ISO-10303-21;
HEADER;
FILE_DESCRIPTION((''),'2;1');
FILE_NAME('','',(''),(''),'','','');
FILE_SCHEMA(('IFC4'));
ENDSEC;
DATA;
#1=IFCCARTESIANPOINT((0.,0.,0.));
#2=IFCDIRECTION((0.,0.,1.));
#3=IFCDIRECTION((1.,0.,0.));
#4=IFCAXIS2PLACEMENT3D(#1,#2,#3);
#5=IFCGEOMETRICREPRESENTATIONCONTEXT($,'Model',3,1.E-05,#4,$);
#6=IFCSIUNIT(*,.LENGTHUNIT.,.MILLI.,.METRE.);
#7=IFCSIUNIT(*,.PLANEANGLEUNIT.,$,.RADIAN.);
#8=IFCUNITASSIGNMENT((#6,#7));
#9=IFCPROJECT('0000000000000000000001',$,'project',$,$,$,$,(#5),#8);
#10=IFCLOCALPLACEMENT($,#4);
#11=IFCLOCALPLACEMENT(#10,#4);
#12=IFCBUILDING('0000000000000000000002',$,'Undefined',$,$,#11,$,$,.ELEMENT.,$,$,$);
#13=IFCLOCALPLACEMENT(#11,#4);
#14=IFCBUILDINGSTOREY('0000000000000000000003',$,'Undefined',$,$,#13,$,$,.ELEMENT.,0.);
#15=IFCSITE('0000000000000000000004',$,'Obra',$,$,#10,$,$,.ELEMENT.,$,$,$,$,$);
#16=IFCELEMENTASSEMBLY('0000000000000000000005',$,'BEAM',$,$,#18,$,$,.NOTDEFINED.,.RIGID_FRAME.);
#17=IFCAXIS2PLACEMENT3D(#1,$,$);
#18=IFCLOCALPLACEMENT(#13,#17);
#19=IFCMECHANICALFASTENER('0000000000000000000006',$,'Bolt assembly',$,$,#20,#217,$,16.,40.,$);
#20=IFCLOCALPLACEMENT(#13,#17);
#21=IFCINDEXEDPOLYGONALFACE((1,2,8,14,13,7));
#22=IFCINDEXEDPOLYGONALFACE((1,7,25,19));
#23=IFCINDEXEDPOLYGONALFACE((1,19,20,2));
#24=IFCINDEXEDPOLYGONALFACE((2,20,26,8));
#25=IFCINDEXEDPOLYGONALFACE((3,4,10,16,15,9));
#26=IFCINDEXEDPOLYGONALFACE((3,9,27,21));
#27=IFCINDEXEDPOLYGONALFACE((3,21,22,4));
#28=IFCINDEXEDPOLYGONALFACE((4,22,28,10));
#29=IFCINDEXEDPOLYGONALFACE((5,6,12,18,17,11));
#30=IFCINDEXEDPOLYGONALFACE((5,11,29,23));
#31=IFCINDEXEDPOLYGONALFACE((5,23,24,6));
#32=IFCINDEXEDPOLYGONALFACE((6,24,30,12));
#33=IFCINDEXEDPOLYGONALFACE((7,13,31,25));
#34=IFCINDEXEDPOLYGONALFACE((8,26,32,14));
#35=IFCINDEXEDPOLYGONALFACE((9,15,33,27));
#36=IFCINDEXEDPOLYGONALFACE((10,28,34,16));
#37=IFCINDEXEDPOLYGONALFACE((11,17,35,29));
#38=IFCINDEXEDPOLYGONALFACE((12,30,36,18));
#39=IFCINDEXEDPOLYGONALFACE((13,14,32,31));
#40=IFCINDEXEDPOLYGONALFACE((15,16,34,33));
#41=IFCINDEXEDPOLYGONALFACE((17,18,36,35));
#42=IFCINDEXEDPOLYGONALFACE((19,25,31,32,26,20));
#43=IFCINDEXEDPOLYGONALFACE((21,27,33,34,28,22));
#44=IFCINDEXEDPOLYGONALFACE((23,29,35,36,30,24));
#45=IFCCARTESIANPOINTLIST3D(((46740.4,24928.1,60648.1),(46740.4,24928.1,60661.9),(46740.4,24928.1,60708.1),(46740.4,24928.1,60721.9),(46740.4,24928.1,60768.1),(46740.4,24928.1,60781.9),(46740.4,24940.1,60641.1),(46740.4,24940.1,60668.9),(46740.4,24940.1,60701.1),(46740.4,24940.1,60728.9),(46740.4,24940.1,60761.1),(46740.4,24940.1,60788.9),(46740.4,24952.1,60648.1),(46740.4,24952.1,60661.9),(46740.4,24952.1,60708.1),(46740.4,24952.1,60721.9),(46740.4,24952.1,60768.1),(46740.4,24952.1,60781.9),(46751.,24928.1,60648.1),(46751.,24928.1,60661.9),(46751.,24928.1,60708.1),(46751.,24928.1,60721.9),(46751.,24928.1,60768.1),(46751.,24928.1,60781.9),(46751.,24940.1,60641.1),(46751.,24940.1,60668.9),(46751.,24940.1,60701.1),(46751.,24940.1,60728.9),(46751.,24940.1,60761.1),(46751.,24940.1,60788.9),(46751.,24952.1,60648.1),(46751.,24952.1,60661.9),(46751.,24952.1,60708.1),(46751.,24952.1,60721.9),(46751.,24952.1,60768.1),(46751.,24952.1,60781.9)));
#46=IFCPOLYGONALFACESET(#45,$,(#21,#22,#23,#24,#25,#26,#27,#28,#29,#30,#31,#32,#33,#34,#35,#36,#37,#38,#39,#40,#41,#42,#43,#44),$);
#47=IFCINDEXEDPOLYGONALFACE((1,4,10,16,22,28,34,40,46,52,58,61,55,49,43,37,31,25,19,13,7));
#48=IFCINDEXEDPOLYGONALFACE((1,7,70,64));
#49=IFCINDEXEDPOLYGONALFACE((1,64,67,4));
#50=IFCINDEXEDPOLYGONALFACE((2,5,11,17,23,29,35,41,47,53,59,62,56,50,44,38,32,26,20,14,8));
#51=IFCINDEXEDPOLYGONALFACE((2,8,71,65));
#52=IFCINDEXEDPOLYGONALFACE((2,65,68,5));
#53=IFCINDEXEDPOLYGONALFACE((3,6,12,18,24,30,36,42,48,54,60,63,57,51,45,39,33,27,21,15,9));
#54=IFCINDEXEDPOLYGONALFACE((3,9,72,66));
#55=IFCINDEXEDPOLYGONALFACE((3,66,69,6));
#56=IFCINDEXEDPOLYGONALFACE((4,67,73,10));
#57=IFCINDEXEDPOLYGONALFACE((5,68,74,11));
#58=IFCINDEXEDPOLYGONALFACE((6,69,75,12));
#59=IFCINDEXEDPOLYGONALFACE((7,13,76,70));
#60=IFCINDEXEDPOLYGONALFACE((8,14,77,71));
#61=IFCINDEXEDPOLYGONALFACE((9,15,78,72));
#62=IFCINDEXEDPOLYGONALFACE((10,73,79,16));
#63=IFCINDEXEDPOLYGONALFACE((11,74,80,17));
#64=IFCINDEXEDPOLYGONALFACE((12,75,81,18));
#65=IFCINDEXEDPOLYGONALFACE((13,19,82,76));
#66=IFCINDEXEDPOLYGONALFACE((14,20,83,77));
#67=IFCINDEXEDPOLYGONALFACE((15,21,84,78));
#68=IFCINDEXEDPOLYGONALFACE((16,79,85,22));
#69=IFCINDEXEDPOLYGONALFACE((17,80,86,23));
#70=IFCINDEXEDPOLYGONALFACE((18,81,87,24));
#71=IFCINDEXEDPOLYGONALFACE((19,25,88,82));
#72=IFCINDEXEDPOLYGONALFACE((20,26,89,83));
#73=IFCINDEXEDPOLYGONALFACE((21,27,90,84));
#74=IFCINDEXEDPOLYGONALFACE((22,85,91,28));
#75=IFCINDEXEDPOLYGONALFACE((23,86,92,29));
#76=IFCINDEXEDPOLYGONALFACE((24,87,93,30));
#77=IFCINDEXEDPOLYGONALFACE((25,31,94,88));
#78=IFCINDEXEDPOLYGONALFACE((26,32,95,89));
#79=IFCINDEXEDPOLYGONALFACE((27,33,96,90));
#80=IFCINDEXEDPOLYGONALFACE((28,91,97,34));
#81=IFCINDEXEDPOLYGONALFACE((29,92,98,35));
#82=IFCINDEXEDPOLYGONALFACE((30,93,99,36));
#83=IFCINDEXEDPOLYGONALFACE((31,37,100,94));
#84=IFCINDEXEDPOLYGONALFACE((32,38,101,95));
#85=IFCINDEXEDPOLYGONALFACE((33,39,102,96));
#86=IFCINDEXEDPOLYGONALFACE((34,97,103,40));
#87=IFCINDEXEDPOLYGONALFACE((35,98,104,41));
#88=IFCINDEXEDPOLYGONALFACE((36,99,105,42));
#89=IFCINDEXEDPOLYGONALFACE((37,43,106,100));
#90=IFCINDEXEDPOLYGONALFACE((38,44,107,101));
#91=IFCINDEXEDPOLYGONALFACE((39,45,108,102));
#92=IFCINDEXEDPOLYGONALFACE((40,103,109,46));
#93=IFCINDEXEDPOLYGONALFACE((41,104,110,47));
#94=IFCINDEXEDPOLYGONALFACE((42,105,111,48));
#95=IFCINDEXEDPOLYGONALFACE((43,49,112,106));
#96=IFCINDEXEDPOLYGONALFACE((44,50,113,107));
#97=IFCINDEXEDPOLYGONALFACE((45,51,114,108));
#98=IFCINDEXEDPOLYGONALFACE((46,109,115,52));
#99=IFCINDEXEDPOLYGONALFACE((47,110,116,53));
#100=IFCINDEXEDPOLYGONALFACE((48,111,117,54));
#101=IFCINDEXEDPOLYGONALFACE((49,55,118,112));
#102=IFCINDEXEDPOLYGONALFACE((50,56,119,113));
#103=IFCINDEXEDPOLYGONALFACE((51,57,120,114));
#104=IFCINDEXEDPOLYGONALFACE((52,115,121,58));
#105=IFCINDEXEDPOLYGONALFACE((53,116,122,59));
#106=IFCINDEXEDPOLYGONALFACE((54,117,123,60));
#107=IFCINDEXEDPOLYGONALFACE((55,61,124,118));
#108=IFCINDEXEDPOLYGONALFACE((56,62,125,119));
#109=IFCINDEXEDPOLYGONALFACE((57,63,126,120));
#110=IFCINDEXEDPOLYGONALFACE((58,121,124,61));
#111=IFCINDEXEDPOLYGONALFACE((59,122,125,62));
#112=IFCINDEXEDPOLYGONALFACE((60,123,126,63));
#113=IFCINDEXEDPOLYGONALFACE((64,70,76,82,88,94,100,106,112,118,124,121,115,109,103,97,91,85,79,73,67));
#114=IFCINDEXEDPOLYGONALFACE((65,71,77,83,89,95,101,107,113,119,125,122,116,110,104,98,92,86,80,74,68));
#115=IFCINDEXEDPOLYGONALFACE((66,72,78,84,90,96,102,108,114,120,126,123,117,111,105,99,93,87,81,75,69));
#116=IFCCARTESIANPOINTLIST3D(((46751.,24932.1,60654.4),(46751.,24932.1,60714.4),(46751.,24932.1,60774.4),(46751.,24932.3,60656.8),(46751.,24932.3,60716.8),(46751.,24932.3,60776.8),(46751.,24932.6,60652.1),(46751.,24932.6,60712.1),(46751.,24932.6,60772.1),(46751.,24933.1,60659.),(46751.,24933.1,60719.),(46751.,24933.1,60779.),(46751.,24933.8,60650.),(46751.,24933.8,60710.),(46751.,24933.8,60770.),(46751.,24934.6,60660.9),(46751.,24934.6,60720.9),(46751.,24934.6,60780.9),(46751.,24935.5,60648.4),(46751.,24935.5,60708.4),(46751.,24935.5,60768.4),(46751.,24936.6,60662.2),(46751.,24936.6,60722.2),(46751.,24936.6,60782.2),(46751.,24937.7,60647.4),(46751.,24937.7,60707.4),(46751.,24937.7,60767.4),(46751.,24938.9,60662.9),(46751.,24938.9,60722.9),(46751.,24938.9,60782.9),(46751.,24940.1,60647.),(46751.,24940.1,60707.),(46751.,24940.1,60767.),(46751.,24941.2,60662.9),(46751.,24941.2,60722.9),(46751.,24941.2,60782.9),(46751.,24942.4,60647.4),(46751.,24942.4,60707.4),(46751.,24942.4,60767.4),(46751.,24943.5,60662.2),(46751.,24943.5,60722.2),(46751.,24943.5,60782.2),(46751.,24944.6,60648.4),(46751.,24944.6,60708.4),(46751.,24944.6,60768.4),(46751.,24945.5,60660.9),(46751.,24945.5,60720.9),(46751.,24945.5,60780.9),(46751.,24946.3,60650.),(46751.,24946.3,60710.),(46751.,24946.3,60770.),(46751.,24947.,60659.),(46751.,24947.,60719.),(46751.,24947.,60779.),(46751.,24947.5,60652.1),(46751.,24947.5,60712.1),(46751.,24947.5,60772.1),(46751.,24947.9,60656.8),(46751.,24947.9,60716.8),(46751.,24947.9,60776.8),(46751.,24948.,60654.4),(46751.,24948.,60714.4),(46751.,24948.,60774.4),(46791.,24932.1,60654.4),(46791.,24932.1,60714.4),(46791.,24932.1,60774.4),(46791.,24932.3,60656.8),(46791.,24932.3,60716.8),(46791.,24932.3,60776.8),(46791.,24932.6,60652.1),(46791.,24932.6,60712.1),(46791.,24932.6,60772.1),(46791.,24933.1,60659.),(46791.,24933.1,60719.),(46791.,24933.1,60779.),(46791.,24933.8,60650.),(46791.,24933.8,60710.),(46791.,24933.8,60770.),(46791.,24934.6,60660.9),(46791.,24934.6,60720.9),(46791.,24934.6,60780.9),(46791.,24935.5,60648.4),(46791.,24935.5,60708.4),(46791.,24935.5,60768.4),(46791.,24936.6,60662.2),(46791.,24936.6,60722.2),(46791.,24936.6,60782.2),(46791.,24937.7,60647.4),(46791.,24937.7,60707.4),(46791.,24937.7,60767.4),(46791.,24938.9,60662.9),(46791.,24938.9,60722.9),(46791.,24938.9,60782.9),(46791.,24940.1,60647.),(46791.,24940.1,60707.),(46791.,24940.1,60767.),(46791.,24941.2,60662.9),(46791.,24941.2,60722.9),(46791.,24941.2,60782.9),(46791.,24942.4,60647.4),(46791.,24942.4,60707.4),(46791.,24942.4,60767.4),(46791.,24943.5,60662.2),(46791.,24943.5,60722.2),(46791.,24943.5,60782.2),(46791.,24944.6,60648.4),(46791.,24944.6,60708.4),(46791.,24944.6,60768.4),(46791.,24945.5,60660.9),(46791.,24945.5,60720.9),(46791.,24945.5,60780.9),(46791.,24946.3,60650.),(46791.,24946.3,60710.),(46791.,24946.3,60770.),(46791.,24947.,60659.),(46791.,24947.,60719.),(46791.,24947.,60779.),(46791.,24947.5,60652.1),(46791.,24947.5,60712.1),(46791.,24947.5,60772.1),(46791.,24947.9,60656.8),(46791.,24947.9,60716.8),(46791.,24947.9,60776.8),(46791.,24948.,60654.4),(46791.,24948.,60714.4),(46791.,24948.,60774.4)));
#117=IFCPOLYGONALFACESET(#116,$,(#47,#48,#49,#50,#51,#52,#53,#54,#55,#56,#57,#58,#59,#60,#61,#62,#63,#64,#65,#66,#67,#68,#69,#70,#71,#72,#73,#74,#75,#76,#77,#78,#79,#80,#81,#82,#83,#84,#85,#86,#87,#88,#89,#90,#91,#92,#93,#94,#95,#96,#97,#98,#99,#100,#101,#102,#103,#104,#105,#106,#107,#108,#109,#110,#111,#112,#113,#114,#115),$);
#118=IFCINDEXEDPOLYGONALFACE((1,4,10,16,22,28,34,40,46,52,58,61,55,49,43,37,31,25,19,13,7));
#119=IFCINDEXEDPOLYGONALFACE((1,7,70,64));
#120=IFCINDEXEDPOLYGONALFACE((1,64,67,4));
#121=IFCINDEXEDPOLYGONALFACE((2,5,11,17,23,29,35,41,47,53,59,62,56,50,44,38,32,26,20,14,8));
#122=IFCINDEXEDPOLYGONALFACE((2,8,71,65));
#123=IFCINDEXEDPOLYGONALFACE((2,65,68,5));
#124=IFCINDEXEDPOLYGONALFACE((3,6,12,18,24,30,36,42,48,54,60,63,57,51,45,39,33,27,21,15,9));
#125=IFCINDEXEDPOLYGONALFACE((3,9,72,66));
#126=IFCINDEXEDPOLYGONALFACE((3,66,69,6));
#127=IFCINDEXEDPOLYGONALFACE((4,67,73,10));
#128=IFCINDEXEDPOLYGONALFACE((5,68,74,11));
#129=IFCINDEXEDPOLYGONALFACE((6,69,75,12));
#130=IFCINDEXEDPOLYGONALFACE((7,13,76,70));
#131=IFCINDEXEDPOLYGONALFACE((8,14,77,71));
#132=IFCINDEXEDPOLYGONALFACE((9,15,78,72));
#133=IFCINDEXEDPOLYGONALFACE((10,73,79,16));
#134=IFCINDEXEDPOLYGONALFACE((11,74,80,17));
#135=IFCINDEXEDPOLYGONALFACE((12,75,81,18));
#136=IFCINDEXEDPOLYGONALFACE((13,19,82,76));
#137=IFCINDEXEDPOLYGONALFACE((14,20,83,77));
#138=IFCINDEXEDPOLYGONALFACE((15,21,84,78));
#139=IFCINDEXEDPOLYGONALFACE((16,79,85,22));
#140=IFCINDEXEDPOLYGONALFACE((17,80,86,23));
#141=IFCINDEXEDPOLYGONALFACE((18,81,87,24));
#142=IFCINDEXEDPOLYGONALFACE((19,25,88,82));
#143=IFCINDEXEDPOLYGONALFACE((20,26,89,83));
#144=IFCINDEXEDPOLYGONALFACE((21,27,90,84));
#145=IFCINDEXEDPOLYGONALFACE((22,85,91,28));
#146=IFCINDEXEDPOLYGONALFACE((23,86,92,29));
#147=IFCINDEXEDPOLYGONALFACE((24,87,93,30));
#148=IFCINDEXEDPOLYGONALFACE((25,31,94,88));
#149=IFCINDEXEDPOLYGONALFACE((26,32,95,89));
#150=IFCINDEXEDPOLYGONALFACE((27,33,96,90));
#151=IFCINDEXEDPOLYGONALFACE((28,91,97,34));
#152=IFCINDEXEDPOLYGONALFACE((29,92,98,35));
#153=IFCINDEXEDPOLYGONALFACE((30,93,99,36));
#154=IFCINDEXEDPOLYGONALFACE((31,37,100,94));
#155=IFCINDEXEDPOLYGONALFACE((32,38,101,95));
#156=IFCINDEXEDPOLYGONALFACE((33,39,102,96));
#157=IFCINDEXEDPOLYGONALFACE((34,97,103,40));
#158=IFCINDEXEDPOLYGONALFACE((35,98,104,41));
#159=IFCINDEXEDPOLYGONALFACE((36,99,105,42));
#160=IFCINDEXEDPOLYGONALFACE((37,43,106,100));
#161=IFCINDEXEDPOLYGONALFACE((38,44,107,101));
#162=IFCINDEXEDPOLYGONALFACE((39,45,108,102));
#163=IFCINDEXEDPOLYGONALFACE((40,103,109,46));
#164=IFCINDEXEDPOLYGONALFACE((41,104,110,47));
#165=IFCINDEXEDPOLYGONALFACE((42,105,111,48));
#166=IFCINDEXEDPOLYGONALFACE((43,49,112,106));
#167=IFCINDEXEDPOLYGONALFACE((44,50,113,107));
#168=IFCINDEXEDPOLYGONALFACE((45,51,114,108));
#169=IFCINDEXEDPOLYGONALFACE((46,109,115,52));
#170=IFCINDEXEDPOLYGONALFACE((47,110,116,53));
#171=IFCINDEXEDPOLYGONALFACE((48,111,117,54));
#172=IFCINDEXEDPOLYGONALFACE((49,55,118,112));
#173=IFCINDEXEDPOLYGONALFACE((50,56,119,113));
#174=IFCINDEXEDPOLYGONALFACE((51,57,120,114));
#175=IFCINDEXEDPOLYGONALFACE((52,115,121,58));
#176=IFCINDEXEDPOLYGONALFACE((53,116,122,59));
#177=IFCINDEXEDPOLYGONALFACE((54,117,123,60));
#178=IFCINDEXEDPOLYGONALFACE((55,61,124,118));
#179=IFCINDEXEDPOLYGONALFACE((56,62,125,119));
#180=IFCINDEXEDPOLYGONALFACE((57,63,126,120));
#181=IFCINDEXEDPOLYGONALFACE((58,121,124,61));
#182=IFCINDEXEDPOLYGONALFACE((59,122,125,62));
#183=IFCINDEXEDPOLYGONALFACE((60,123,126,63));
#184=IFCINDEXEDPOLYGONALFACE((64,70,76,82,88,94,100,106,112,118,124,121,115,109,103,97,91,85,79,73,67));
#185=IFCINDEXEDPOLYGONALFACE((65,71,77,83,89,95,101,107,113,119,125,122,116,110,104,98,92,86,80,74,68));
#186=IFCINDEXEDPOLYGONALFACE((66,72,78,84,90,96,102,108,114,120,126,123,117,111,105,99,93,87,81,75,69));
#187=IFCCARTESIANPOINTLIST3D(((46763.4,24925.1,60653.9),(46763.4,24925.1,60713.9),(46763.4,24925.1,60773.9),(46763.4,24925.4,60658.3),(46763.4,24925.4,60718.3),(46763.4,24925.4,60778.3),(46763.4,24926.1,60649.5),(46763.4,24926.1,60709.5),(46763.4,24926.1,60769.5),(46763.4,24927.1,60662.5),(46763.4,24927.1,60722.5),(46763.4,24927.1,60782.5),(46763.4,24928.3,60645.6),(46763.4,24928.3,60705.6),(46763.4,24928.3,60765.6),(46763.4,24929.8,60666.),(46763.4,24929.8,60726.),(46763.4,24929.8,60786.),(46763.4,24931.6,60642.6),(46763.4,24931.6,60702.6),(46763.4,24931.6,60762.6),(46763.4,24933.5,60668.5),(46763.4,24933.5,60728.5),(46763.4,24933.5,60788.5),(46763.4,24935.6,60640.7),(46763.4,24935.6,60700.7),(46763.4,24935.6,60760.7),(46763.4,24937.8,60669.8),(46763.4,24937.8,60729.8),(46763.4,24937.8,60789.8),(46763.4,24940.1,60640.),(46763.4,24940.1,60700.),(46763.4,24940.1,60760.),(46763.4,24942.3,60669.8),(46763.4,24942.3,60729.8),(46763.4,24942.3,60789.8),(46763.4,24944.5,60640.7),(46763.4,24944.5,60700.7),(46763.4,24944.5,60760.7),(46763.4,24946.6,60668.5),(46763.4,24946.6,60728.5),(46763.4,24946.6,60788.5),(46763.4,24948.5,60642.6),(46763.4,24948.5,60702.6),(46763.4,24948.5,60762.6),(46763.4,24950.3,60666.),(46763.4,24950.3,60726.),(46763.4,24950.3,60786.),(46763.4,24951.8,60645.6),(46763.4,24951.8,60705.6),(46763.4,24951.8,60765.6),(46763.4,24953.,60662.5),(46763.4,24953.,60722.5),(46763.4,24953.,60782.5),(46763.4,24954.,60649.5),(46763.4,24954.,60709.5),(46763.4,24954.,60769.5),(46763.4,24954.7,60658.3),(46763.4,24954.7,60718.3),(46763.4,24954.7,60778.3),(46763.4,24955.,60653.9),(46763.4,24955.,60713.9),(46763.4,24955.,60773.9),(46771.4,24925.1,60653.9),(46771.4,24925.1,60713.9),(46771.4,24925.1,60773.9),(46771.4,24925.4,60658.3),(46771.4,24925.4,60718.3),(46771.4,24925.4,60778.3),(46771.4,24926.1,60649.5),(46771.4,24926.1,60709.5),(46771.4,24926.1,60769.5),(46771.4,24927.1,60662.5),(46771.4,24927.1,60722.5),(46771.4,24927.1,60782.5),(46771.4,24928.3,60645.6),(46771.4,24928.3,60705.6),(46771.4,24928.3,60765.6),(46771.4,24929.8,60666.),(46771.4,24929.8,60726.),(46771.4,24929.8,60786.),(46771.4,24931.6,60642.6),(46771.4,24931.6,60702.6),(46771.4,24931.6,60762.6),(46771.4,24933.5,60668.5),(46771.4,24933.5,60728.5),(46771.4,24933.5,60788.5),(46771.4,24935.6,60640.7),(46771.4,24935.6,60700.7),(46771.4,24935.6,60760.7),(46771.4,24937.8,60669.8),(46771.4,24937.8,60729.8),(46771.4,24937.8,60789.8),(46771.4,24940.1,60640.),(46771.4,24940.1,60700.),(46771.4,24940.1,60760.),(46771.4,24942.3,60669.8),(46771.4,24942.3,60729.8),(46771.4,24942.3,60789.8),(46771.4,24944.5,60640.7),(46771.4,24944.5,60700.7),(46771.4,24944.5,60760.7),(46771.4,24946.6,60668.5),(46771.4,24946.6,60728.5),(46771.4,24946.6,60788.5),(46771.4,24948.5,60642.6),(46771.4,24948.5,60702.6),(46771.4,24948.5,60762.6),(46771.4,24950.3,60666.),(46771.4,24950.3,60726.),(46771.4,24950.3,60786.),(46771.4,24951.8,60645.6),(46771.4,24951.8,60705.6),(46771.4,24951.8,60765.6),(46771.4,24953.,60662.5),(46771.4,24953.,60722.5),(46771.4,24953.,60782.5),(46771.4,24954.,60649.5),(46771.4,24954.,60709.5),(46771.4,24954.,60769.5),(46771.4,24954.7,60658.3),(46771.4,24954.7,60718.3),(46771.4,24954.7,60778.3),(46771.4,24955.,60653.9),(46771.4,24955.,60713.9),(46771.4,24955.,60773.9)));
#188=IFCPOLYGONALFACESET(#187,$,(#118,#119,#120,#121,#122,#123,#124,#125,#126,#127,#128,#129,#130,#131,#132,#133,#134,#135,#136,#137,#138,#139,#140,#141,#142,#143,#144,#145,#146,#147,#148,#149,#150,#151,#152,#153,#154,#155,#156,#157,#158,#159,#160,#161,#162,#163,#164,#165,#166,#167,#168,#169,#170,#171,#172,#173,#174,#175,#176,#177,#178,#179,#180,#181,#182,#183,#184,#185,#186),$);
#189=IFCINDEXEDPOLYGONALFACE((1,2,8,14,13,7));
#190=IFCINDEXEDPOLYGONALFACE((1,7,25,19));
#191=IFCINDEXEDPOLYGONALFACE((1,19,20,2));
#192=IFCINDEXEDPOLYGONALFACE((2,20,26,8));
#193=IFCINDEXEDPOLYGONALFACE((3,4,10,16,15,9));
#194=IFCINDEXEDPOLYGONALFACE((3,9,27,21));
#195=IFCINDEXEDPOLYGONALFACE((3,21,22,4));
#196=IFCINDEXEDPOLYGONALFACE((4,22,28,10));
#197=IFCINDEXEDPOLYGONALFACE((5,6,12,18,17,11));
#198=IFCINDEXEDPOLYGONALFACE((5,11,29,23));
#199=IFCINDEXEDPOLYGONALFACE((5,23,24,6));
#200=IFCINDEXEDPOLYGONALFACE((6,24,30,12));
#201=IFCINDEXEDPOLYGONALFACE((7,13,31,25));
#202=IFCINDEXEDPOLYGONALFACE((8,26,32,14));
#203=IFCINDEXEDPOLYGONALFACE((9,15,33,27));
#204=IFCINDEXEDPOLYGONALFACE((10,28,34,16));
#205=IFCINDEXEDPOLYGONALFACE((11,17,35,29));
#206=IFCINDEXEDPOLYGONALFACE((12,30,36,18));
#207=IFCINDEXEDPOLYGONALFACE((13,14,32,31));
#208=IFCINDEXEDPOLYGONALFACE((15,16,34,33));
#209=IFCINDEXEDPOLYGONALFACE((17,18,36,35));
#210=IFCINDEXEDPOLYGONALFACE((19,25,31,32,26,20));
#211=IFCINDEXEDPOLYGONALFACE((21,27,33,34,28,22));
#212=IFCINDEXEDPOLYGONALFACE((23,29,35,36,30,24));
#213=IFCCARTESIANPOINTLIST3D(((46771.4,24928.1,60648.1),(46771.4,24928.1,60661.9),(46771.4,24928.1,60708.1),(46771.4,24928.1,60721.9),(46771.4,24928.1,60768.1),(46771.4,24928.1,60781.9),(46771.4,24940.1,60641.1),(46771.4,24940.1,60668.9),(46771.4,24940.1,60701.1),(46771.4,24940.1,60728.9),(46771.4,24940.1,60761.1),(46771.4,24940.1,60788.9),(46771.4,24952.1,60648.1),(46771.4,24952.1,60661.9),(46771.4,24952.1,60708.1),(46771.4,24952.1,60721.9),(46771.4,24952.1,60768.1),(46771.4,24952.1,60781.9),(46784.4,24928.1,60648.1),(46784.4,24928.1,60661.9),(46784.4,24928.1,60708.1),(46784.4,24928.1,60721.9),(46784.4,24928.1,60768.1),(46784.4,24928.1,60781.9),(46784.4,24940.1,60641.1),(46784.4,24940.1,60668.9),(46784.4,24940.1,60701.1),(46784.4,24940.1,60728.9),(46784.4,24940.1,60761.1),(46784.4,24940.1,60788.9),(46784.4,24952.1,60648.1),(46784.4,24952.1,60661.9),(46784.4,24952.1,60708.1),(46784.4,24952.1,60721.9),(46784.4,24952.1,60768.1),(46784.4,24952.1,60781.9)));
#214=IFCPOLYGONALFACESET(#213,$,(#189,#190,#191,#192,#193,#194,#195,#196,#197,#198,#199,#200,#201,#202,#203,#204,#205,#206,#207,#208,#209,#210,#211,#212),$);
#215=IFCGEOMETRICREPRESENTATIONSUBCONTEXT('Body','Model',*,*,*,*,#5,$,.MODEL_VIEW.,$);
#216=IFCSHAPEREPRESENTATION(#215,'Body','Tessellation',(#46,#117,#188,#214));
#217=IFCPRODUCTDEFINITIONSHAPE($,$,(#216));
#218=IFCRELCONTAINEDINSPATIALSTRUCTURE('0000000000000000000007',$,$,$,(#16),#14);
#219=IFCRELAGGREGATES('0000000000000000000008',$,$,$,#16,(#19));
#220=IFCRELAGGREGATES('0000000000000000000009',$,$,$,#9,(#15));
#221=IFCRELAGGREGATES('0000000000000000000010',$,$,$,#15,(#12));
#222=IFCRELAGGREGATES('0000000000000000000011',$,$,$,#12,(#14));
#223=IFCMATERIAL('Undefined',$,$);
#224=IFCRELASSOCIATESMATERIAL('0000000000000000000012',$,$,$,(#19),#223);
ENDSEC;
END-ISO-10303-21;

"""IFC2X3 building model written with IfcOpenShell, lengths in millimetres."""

from ifc_helpers import new_model, si_unit, frame, origin_with_axes, origin_2d_with_axis, place, context, subcontext, project, spatial, polyline, circle, outline, extrude, source, transform, mapped, material, element, aggregate, save


model = new_model("IFC2X3")

# Units and contexts
model_context = context("Model", 3, precision=1e-05, world=origin_with_axes())
body_context = subcontext(model_context, "Body", "Model", "MODEL_VIEW")
ifc_project = project(units=[si_unit("LENGTHUNIT", "METRE", prefix="MILLI"), si_unit("PLANEANGLEUNIT", "RADIAN")], contexts=[model_context])

# Site, building, storey
site_placement = place(None, origin_with_axes())
site = spatial("IfcSite", under=ifc_project, at=site_placement, Name="Obra", CompositionType="ELEMENT")
building_placement = place(site_placement, origin_with_axes())
building = spatial("IfcBuilding", under=site, at=building_placement, Name="Undefined", CompositionType="ELEMENT")
storey_placement = place(building_placement, origin_with_axes())
storey = spatial("IfcBuildingStorey", under=building, at=storey_placement, Name="Undefined", CompositionType="ELEMENT", Elevation=0.0)

# Element assembly
ifc_material_1 = material(Name="Undefined")
assembly_1_placement = place(storey_placement, origin_with_axes())
assembly_1 = element("IfcElementAssembly", 1, at=assembly_1_placement, inside=storey, Name="BEAM", AssemblyPlace="NOTDEFINED", PredefinedType="RIGID_FRAME")

# Mechanical fastener
shared_shape_1 = source(origin_with_axes(), body_context, "Body", "SweptSolid", [
    extrude(outline(polyline([(13.9, 0.0), (6.9, 12.0), (-6.9, 12.0), (-13.9, 0.0), (-6.9, -12.0), (6.9, -12.0), (13.9, 0.0)])), frame((0.0, -19.7, 0.0), z_axis=(0.0, 1.0, 0.0), x_axis=(1.0, 0.0, 0.0)), (0.0, 0.0, 1.0), 10.6),
    extrude(circle(Radius=8.0, at=origin_2d_with_axis()), frame((0.0, -9.1, 0.0), z_axis=(0.0, 1.0, 0.0), x_axis=(1.0, 0.0, 0.0)), (0.0, 0.0, 1.0), 40.0),
    extrude(circle(Radius=15.0, at=origin_2d_with_axis()), frame((0.0, 3.3, 0.0), z_axis=(0.0, 1.0, 0.0), x_axis=(1.0, 0.0, 0.0)), (0.0, 0.0, 1.0), 8.0),
    extrude(outline(polyline([(13.9, 0.0), (6.9, 12.0), (-6.9, 12.0), (-13.9, 0.0), (-6.9, -12.0), (6.9, -12.0), (13.9, 0.0)])), frame((0.0, 11.3, 0.0), z_axis=(0.0, 1.0, 0.0), x_axis=(1.0, 0.0, 0.0)), (0.0, 0.0, 1.0), 13.0),
])
mechanical_fastener_1_placement = place(assembly_1_placement, frame((46760.1, 24990.1, 60835.0), z_axis=(0.000002, -1.0, 0.0), x_axis=(0.0, 0.0, -1.0)))
mechanical_fastener_1 = element("IfcMechanicalFastener", 2, at=mechanical_fastener_1_placement, material=ifc_material_1, Name="Bolt assembly", NominalDiameter=16.0, NominalLength=40.0, context=body_context, shape_type="MappedRepresentation", body=[
    mapped(shared_shape_1, transform((60.0, 0.0, 50.0))),
    mapped(shared_shape_1, transform((120.0, 0.0, 50.0))),
    mapped(shared_shape_1, transform((180.0, 0.0, 50.0))),
])
aggregate(assembly_1, [mechanical_fastener_1])

save(model, "model.ifc")
